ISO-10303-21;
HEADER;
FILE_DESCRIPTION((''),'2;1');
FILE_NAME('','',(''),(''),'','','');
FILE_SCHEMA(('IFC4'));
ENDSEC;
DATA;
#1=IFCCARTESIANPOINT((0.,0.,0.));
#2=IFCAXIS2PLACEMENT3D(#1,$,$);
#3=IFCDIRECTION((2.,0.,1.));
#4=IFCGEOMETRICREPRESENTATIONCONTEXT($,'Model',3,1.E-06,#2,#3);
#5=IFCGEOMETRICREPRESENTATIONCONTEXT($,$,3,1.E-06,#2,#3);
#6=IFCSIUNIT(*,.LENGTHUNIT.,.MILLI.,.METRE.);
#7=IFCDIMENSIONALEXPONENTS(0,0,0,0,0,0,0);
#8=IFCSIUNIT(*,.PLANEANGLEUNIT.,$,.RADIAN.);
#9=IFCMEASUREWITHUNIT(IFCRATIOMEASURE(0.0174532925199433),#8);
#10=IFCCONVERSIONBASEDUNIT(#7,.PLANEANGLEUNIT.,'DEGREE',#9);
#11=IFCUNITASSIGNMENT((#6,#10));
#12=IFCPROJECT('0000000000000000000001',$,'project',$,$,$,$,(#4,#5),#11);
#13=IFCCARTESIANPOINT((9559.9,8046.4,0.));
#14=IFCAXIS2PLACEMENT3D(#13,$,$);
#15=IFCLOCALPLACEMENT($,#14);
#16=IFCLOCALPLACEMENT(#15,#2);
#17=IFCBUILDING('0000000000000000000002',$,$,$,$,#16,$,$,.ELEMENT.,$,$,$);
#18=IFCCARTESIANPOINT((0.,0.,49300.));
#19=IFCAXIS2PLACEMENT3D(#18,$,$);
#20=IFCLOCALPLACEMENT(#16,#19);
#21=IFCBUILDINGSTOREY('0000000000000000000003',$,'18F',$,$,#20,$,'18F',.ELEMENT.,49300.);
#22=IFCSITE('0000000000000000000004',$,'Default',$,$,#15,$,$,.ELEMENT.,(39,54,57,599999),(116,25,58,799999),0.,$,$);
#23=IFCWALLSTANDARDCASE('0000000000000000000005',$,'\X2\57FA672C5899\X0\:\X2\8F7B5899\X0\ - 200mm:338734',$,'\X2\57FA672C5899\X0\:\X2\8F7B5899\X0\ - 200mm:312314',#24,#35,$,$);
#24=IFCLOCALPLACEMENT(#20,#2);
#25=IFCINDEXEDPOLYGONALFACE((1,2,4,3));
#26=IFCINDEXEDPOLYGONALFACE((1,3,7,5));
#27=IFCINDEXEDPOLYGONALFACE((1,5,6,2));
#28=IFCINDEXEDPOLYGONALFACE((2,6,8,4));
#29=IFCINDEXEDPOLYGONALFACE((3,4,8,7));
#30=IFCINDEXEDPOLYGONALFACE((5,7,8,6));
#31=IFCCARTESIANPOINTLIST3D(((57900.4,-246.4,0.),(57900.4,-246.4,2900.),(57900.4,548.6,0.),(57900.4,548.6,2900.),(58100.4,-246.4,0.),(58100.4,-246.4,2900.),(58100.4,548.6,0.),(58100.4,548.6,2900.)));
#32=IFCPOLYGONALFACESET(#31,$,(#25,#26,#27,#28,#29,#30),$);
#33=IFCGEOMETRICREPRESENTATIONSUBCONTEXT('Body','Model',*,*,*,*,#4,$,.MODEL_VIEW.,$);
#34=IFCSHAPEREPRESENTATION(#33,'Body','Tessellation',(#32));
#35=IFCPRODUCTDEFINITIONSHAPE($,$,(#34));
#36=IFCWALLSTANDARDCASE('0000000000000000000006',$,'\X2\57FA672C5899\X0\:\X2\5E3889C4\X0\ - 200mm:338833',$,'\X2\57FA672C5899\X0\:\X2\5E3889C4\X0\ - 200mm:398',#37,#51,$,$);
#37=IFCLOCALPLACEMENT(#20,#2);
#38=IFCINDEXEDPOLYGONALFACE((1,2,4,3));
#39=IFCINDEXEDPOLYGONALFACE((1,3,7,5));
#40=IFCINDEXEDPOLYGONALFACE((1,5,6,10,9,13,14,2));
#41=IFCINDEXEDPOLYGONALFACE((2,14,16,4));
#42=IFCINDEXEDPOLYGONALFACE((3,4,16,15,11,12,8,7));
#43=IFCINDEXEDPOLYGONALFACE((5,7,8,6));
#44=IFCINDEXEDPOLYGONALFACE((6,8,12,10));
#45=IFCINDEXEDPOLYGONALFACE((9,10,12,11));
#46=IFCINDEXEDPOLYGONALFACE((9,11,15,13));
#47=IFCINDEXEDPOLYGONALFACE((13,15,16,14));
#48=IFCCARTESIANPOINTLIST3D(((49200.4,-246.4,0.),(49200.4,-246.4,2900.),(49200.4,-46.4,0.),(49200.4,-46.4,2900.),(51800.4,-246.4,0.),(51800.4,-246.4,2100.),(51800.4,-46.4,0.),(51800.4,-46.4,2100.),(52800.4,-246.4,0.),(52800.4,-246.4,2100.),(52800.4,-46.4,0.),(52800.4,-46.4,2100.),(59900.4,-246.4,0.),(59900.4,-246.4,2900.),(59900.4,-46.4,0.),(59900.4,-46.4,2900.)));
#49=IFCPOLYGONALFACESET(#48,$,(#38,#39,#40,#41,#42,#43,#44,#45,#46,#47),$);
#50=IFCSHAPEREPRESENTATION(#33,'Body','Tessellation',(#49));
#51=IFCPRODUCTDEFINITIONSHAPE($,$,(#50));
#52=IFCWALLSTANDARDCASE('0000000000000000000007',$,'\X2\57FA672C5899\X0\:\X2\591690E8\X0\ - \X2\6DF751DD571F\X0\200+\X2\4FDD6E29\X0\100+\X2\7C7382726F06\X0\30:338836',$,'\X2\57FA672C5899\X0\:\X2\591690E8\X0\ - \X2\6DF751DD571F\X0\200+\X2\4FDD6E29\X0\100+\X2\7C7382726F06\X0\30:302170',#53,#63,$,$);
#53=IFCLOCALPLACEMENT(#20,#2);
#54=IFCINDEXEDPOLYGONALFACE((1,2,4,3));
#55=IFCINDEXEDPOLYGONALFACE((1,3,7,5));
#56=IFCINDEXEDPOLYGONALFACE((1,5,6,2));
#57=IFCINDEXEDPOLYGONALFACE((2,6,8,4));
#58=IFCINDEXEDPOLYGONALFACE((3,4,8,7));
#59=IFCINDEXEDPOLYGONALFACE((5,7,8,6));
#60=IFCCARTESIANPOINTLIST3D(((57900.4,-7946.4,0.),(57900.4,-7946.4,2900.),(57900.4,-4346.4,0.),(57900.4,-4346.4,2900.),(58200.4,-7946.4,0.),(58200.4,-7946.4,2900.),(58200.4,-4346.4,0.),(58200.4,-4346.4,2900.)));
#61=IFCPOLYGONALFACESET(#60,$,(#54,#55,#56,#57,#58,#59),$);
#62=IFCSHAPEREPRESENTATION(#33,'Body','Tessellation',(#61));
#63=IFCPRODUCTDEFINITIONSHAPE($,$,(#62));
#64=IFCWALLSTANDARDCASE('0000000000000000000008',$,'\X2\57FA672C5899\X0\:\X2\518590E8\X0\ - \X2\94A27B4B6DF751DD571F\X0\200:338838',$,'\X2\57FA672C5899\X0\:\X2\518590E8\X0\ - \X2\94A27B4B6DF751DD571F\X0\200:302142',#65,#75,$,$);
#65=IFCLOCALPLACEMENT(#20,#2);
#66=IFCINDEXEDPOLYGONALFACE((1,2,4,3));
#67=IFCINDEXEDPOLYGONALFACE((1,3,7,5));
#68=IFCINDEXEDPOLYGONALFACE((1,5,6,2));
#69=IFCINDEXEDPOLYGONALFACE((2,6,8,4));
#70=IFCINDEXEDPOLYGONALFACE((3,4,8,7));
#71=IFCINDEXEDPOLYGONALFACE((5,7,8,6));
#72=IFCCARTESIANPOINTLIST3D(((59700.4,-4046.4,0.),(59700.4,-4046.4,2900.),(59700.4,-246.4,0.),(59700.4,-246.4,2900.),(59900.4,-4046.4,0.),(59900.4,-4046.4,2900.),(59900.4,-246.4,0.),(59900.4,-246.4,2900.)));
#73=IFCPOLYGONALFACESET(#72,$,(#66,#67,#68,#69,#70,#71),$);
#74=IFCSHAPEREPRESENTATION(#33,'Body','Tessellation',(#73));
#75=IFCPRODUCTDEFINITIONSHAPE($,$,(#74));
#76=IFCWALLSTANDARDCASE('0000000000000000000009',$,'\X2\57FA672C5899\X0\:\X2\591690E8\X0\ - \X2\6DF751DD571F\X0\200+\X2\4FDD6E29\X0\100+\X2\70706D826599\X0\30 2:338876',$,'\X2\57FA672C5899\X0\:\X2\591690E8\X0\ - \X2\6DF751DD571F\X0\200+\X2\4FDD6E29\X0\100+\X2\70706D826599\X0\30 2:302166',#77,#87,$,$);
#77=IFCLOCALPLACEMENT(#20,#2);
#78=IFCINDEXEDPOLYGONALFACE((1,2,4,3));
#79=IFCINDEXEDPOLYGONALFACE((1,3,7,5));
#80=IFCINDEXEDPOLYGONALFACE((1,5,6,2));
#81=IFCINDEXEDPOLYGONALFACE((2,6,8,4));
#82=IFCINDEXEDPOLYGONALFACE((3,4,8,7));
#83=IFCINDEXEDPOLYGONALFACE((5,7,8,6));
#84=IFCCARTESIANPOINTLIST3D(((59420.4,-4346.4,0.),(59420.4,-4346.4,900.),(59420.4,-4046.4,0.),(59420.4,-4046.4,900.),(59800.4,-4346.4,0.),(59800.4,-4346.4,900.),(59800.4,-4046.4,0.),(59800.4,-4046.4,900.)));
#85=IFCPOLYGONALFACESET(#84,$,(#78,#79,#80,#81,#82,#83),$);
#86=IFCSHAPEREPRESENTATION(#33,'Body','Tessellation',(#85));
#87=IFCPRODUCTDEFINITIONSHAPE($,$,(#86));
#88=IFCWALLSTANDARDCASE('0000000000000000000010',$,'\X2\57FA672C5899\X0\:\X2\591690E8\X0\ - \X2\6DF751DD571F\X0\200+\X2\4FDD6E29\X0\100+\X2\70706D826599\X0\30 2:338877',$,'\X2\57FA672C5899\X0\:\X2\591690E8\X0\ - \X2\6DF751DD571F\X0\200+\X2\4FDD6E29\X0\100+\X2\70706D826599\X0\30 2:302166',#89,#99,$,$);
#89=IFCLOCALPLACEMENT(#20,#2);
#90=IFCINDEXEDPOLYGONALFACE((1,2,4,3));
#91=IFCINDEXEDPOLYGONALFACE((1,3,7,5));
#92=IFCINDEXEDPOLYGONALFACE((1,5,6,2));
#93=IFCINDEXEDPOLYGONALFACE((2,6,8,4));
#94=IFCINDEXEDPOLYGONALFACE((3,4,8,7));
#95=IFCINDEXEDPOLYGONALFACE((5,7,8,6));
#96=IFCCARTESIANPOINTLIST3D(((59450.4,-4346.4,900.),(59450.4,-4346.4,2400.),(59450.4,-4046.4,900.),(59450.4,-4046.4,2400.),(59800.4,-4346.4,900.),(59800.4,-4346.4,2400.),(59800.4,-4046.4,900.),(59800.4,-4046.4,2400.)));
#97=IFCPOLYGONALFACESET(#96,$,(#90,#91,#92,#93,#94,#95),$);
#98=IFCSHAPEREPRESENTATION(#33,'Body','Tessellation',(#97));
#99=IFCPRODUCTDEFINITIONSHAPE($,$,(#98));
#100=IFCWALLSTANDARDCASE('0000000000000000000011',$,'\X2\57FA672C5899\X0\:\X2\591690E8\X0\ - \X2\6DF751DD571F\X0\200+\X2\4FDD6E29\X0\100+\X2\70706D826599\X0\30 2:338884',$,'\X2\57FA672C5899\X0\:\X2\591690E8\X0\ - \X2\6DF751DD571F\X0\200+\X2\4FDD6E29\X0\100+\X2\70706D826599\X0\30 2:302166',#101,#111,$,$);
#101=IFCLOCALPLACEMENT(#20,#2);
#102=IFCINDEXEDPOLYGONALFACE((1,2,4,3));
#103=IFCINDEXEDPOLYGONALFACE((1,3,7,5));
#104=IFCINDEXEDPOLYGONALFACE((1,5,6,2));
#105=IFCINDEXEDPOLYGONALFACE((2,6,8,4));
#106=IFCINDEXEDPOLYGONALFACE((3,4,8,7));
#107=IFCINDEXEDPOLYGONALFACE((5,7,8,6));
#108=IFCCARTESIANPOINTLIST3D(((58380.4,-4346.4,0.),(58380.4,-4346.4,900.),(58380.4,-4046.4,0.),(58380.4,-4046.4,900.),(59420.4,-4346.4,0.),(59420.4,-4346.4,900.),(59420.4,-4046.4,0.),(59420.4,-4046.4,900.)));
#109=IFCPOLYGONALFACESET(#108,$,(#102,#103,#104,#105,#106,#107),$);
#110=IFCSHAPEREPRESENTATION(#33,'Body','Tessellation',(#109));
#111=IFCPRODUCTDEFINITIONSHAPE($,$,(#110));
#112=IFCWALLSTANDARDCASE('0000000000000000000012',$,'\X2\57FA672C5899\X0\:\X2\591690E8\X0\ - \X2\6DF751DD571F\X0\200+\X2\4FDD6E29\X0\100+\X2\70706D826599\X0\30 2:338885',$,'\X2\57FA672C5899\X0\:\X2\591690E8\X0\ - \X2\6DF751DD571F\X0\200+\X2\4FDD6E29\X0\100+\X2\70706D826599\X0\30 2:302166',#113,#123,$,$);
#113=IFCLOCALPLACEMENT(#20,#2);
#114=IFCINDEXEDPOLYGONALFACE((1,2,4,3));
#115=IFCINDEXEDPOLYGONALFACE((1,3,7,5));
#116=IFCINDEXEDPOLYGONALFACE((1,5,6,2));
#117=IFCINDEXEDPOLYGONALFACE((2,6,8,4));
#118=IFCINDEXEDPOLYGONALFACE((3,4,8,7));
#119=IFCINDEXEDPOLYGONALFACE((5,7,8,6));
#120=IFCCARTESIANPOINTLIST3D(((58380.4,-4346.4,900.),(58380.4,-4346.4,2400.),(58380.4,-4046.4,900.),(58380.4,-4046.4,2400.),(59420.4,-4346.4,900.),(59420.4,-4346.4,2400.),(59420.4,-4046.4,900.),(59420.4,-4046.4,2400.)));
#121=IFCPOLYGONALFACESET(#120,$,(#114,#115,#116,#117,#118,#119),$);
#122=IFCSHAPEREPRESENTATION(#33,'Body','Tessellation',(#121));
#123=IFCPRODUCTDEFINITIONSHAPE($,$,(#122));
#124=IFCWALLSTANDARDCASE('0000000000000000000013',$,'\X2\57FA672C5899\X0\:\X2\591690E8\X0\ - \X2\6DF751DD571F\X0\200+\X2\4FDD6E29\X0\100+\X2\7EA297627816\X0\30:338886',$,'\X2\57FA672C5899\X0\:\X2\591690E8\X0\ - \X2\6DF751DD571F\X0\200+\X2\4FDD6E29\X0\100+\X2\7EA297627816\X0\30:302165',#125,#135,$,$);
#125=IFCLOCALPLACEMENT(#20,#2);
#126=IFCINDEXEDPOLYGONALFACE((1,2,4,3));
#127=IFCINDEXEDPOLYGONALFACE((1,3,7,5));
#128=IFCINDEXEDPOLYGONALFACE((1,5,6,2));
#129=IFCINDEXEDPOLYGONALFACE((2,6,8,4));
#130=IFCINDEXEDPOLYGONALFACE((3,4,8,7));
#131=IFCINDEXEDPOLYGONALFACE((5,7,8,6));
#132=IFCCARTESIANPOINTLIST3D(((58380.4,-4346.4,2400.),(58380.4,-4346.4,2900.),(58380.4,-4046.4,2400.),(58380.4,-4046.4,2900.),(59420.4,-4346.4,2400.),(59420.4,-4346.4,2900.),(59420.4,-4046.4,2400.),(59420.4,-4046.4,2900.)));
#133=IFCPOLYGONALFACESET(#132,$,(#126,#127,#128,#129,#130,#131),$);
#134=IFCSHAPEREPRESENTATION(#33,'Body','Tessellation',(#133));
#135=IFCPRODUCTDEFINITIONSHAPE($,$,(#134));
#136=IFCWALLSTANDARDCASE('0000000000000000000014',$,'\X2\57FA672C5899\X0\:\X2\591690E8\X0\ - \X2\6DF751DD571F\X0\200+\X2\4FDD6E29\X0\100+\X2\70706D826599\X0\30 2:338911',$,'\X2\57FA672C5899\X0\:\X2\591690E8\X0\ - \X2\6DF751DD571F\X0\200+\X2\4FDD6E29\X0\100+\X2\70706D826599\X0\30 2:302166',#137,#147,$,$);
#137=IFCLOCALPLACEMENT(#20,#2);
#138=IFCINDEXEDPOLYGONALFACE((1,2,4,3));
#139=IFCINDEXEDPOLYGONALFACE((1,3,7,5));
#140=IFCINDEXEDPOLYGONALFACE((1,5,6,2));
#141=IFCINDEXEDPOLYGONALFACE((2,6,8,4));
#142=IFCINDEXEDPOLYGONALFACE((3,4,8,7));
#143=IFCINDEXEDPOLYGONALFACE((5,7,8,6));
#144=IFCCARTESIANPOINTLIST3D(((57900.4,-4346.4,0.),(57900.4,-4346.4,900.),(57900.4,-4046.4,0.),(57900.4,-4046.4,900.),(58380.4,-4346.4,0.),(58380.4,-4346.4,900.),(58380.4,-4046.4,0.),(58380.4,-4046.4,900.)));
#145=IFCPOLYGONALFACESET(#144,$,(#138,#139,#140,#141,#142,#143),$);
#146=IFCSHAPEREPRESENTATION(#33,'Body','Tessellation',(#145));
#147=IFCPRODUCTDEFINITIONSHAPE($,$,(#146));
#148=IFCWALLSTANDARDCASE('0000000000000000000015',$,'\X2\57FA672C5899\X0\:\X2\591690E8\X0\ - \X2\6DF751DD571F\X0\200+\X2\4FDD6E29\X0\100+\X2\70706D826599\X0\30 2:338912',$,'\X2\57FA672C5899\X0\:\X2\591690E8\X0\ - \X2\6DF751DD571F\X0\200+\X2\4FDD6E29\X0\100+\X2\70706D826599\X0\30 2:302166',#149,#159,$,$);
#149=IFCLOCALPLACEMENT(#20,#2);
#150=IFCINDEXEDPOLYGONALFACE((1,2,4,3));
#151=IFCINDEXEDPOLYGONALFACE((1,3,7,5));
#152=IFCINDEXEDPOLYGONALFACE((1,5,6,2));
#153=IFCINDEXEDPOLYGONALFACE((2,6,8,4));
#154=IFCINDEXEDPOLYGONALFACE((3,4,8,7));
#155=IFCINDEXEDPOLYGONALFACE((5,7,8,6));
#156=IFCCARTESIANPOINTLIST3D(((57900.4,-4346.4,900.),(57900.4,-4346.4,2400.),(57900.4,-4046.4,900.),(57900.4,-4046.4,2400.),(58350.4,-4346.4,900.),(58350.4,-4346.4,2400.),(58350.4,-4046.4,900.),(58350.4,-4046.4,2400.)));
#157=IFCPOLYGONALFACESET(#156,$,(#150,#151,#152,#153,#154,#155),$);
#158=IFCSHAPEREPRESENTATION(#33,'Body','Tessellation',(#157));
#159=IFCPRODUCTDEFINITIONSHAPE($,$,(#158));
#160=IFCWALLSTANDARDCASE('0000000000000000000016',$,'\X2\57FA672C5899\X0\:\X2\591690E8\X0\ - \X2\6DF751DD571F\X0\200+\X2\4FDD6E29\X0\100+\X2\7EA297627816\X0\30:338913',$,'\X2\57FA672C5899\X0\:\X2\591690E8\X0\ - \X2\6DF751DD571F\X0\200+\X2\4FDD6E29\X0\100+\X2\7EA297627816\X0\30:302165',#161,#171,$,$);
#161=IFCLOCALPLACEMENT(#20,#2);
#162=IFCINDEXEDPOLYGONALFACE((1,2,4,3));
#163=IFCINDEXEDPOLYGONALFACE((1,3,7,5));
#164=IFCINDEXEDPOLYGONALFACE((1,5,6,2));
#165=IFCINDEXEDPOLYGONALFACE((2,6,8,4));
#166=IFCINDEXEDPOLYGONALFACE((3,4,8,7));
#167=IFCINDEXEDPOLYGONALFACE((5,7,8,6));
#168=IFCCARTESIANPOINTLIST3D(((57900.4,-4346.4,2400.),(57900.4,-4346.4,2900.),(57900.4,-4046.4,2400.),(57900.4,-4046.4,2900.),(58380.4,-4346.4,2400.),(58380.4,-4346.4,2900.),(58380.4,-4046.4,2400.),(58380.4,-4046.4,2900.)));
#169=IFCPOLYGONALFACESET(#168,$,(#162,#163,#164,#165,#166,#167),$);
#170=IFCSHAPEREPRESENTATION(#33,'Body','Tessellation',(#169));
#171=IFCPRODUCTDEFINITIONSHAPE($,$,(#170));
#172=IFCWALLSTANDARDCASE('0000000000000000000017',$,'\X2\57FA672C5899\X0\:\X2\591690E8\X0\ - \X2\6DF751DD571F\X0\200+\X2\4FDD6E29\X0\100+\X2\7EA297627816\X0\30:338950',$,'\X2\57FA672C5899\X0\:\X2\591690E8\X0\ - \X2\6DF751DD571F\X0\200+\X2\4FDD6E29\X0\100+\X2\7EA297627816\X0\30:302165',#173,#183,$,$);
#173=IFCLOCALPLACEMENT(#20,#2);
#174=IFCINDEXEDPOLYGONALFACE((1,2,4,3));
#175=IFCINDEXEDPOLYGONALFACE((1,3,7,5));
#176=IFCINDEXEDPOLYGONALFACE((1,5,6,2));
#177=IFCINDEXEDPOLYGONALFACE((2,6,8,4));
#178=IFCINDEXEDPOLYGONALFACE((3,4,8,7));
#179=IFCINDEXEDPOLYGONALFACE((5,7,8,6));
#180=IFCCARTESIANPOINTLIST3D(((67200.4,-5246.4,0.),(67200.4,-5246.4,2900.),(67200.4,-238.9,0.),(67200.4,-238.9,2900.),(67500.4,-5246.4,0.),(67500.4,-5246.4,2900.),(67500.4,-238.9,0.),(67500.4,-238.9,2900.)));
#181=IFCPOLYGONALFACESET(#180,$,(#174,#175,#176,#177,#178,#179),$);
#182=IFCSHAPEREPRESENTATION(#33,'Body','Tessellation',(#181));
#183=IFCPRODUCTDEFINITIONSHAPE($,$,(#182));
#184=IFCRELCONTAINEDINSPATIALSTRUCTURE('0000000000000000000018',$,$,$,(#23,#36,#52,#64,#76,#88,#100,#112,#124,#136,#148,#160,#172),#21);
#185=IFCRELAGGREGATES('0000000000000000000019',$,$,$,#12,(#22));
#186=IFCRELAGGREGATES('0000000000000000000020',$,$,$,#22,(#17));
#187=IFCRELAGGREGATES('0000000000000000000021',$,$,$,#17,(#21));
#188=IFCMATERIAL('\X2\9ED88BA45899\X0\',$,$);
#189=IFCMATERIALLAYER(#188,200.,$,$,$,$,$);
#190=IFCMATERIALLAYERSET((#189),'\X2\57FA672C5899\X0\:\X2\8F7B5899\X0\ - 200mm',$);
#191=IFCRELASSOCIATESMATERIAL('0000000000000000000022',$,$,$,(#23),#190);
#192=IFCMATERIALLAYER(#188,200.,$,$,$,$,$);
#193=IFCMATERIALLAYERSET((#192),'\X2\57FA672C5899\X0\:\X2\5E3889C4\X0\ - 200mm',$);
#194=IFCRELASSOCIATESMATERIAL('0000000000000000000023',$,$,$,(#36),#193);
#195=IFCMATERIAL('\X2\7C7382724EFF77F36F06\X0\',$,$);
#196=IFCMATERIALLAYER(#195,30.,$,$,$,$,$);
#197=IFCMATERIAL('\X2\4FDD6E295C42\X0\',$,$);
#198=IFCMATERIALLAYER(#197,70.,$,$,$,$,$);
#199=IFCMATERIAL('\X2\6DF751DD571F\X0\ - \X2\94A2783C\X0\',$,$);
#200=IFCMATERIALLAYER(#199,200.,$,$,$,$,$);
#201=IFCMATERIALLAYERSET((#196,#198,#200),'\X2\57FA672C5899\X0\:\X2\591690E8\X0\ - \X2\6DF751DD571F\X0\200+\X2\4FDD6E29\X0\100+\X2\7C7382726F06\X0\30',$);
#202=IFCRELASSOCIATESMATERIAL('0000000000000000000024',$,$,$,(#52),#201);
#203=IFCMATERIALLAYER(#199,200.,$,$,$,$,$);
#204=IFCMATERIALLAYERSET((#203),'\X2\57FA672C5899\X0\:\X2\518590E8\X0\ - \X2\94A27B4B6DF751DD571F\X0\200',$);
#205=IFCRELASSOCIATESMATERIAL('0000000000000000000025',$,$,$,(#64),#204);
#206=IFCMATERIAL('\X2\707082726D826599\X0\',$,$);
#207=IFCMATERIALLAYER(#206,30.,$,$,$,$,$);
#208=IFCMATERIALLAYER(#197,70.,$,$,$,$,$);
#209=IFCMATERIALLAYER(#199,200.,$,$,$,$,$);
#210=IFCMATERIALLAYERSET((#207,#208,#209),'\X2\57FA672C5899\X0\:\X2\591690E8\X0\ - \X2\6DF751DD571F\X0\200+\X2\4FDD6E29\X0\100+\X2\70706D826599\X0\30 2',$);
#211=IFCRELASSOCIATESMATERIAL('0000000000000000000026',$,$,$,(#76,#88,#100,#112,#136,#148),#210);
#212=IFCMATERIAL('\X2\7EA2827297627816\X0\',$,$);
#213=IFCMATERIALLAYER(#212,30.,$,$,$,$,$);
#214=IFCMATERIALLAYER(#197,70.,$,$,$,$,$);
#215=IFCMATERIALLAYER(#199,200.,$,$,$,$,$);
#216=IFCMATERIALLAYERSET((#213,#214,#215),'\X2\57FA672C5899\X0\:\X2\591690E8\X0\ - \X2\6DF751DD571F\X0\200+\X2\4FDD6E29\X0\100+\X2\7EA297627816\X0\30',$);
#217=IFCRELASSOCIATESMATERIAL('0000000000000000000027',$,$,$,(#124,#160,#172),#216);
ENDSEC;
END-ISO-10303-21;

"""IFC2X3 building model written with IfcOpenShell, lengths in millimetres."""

from ifc_helpers import new_model, entity, si_unit, converted_unit, direction, frame, frame_2d, origin, place, context, subcontext, project, spatial, rectangle, extrude, material, layer, layer_set, layer_usage, element, save


model = new_model("IFC2X3")

# Units and contexts
model_context = context("Model", 3, precision=1e-06, world=origin(), true_north=direction((2.0, 0.0, 1.0)))
context_of_model = context(None, 3, precision=1e-06, world=origin(), true_north=direction((2.0, 0.0, 1.0)))
body_context = subcontext(model_context, "Body", "Model", "MODEL_VIEW")
ifc_project = project(units=[si_unit("LENGTHUNIT", "METRE", prefix="MILLI"), converted_unit("PLANEANGLEUNIT", "DEGREE", entity("IfcRatioMeasure", 0.0174532925199433), si_unit("PLANEANGLEUNIT", "RADIAN"), dimensions=[0, 0, 0, 0, 0, 0, 0])], contexts=[model_context, context_of_model])

# Site, building, storey
site_placement = place(None, frame((9559.9, 8046.4, 0.0)))
site = spatial("IfcSite", under=ifc_project, at=site_placement, Name="Default", CompositionType="ELEMENT", RefLatitude=(39, 54, 57, 599999), RefLongitude=(116, 25, 58, 799999), RefElevation=0.0)
building_placement = place(site_placement, origin())
building = spatial("IfcBuilding", under=site, at=building_placement, CompositionType="ELEMENT")
storey_placement = place(building_placement, frame((0.0, 0.0, 49300.0)))
storey = spatial("IfcBuildingStorey", under=building, at=storey_placement, Name="18F", LongName="18F", CompositionType="ELEMENT", Elevation=49300.0)

# Wall
ifc_material_1 = material(Name="默认墙")
ifc_layer_1 = layer(ifc_material_1, 200.0)
ifc_layer_set_1 = layer_set([ifc_layer_1], Name="基本墙:轻墙 - 200mm")
ifc_layer_usage_1 = layer_usage(ifc_layer_set_1, "AXIS2", "POSITIVE", -100.0)
wall_1_placement = place(storey_placement, frame((58000.4, -246.4, 0.0), z_axis=(0.0, 0.0, 1.0), x_axis=(0.0, 1.0, 0.0)))
element("IfcWallStandardCase", 1, at=wall_1_placement, inside=storey, material=ifc_layer_usage_1, Name="基本墙:轻墙 - 200mm:338734", ObjectType="基本墙:轻墙 - 200mm:312314", context=body_context, shape_type="SweptSolid", body=[
    extrude(rectangle(XDim=795.0, YDim=200.0, at=frame_2d((397.5, 0.0), x_axis=(-1.0, 0.0))), origin(), (0.0, 0.0, 1.0), 2900.0),
])

# Wall, opening
ifc_layer_2 = layer(ifc_material_1, 200.0)
ifc_layer_set_2 = layer_set([ifc_layer_2], Name="基本墙:常规 - 200mm")
ifc_layer_usage_2 = layer_usage(ifc_layer_set_2, "AXIS2", "POSITIVE", -100.0)
wall_2_placement = place(storey_placement, frame((59900.4, -146.4, 0.0), z_axis=(0.0, 0.0, 1.0), x_axis=(-1.0, 0.0, 0.0)))
wall_2 = element("IfcWallStandardCase", 2, at=wall_2_placement, inside=storey, material=ifc_layer_usage_2, Name="基本墙:常规 - 200mm:338833", ObjectType="基本墙:常规 - 200mm:398", context=body_context, shape_type="SweptSolid", body=[
    extrude(rectangle(XDim=10700.0, YDim=200.0, at=frame_2d((5350.0, 0.0), x_axis=(-1.0, 0.0))), origin(), (0.0, 0.0, 1.0), 2900.0),
])
opening_1_placement = place(wall_2_placement, frame((8100.0, 100.0, 0.0)))
element("IfcOpeningElement", 3, at=opening_1_placement, cuts=wall_2, ObjectType="Opening", context=body_context, shape_type="SweptSolid", body=[
    extrude(rectangle(XDim=2100.0, YDim=1000.0, at=frame_2d((1050.0, 500.0), x_axis=(1.0, 0.0))), frame((0.0, 0.0, 0.0), z_axis=(0.0, -1.0, 0.0), x_axis=(0.0, 0.0, 1.0)), (0.0, 0.0, 1.0), 200.0),
])

# Walls
ifc_material_2 = material(Name="米色仿石漆")
ifc_layer_3 = layer(ifc_material_2, 30.0)
ifc_material_3 = material(Name="保温层")
ifc_layer_4 = layer(ifc_material_3, 70.0)
ifc_material_4 = material(Name="混凝土 - 钢砼")
ifc_layer_5 = layer(ifc_material_4, 200.0)
ifc_layer_set_3 = layer_set([ifc_layer_3, ifc_layer_4, ifc_layer_5], Name="基本墙:外部 - 混凝土200+保温100+米色漆30")
ifc_layer_usage_3 = layer_usage(ifc_layer_set_3, "AXIS2", "POSITIVE", -150.0)
wall_3_placement = place(storey_placement, frame((58050.4, -7946.4, 0.0), z_axis=(0.0, 0.0, 1.0), x_axis=(0.0, 1.0, 0.0)))
element("IfcWallStandardCase", 4, at=wall_3_placement, inside=storey, material=ifc_layer_usage_3, Name="基本墙:外部 - 混凝土200+保温100+米色漆30:338836", ObjectType="基本墙:外部 - 混凝土200+保温100+米色漆30:302170", context=body_context, shape_type="SweptSolid", body=[
    extrude(rectangle(XDim=3600.0, YDim=300.0, at=frame_2d((1800.0, 0.0), x_axis=(-1.0, 0.0))), origin(), (0.0, 0.0, 1.0), 2900.0),
])
ifc_layer_6 = layer(ifc_material_4, 200.0)
ifc_layer_set_4 = layer_set([ifc_layer_6], Name="基本墙:内部 - 钢筋混凝土200")
ifc_layer_usage_4 = layer_usage(ifc_layer_set_4, "AXIS2", "POSITIVE", -100.0)
wall_4_placement = place(storey_placement, frame((59800.4, -4046.4, 0.0), z_axis=(0.0, 0.0, 1.0), x_axis=(0.0, 1.0, 0.0)))
element("IfcWallStandardCase", 5, at=wall_4_placement, inside=storey, material=ifc_layer_usage_4, Name="基本墙:内部 - 钢筋混凝土200:338838", ObjectType="基本墙:内部 - 钢筋混凝土200:302142", context=body_context, shape_type="SweptSolid", body=[
    extrude(rectangle(XDim=3800.0, YDim=200.0, at=frame_2d((1900.0, 0.0), x_axis=(-1.0, 0.0))), origin(), (0.0, 0.0, 1.0), 2900.0),
])
ifc_material_5 = material(Name="灰色涂料")
ifc_layer_7 = layer(ifc_material_5, 30.0)
ifc_layer_8 = layer(ifc_material_3, 70.0)
ifc_layer_9 = layer(ifc_material_4, 200.0)
ifc_layer_set_5 = layer_set([ifc_layer_7, ifc_layer_8, ifc_layer_9], Name="基本墙:外部 - 混凝土200+保温100+灰涂料30 2")
ifc_layer_usage_5 = layer_usage(ifc_layer_set_5, "AXIS2", "POSITIVE", -150.0)
wall_5_placement = place(storey_placement, frame((59420.4, -4196.4, 0.0)))
element("IfcWallStandardCase", 6, at=wall_5_placement, inside=storey, material=ifc_layer_usage_5, Name="基本墙:外部 - 混凝土200+保温100+灰涂料30 2:338876", ObjectType="基本墙:外部 - 混凝土200+保温100+灰涂料30 2:302166", context=body_context, shape_type="SweptSolid", body=[
    extrude(rectangle(XDim=380.0, YDim=300.0, at=frame_2d((190.0, 0.0), x_axis=(-1.0, 0.0))), origin(), (0.0, 0.0, 1.0), 900.0),
])
ifc_layer_usage_6 = layer_usage(ifc_layer_set_5, "AXIS2", "POSITIVE", -150.0)
wall_6_placement = place(storey_placement, frame((59450.4, -4196.4, 900.0)))
element("IfcWallStandardCase", 7, at=wall_6_placement, inside=storey, material=ifc_layer_usage_6, Name="基本墙:外部 - 混凝土200+保温100+灰涂料30 2:338877", ObjectType="基本墙:外部 - 混凝土200+保温100+灰涂料30 2:302166", context=body_context, shape_type="SweptSolid", body=[
    extrude(rectangle(XDim=350.0, YDim=300.0, at=frame_2d((175.0, 0.0), x_axis=(-1.0, 0.0))), origin(), (0.0, 0.0, 1.0), 1500.0),
])

# Shared definitions
ifc_material_6 = material(Name="红色面砖")
ifc_layer_10 = layer(ifc_material_6, 30.0)
ifc_layer_11 = layer(ifc_material_3, 70.0)
ifc_layer_12 = layer(ifc_material_4, 200.0)
ifc_layer_set_6 = layer_set([ifc_layer_10, ifc_layer_11, ifc_layer_12], Name="基本墙:外部 - 混凝土200+保温100+红面砖30")

# Walls
ifc_layer_usage_7 = layer_usage(ifc_layer_set_5, "AXIS2", "POSITIVE", -150.0)
wall_7_placement = place(storey_placement, frame((58380.4, -4196.4, 0.0)))
element("IfcWallStandardCase", 8, at=wall_7_placement, inside=storey, material=ifc_layer_usage_7, Name="基本墙:外部 - 混凝土200+保温100+灰涂料30 2:338884", ObjectType="基本墙:外部 - 混凝土200+保温100+灰涂料30 2:302166", context=body_context, shape_type="SweptSolid", body=[
    extrude(rectangle(XDim=1040.0, YDim=300.0, at=frame_2d((520.0, 0.0), x_axis=(-1.0, 0.0))), origin(), (0.0, 0.0, 1.0), 900.0),
])
ifc_layer_usage_8 = layer_usage(ifc_layer_set_5, "AXIS2", "POSITIVE", -150.0)
wall_8_placement = place(storey_placement, frame((58380.4, -4196.4, 900.0)))
element("IfcWallStandardCase", 9, at=wall_8_placement, inside=storey, material=ifc_layer_usage_8, Name="基本墙:外部 - 混凝土200+保温100+灰涂料30 2:338885", ObjectType="基本墙:外部 - 混凝土200+保温100+灰涂料30 2:302166", context=body_context, shape_type="SweptSolid", body=[
    extrude(rectangle(XDim=1040.0, YDim=300.0, at=frame_2d((520.0, 0.0), x_axis=(-1.0, 0.0))), origin(), (0.0, 0.0, 1.0), 1500.0),
])
ifc_layer_usage_9 = layer_usage(ifc_layer_set_6, "AXIS2", "POSITIVE", -150.0)
wall_9_placement = place(storey_placement, frame((58380.4, -4196.4, 2400.0)))
element("IfcWallStandardCase", 10, at=wall_9_placement, inside=storey, material=ifc_layer_usage_9, Name="基本墙:外部 - 混凝土200+保温100+红面砖30:338886", ObjectType="基本墙:外部 - 混凝土200+保温100+红面砖30:302165", context=body_context, shape_type="SweptSolid", body=[
    extrude(rectangle(XDim=1040.0, YDim=300.0, at=frame_2d((520.0, 0.0), x_axis=(-1.0, 0.0))), origin(), (0.0, 0.0, 1.0), 500.0),
])
ifc_layer_usage_10 = layer_usage(ifc_layer_set_5, "AXIS2", "POSITIVE", -150.0)
wall_10_placement = place(storey_placement, frame((57900.4, -4196.4, 0.0)))
element("IfcWallStandardCase", 11, at=wall_10_placement, inside=storey, material=ifc_layer_usage_10, Name="基本墙:外部 - 混凝土200+保温100+灰涂料30 2:338911", ObjectType="基本墙:外部 - 混凝土200+保温100+灰涂料30 2:302166", context=body_context, shape_type="SweptSolid", body=[
    extrude(rectangle(XDim=480.0, YDim=300.0, at=frame_2d((240.0, 0.0), x_axis=(-1.0, 0.0))), origin(), (0.0, 0.0, 1.0), 900.0),
])
ifc_layer_usage_11 = layer_usage(ifc_layer_set_5, "AXIS2", "POSITIVE", -150.0)
wall_11_placement = place(storey_placement, frame((57900.4, -4196.4, 900.0)))
element("IfcWallStandardCase", 12, at=wall_11_placement, inside=storey, material=ifc_layer_usage_11, Name="基本墙:外部 - 混凝土200+保温100+灰涂料30 2:338912", ObjectType="基本墙:外部 - 混凝土200+保温100+灰涂料30 2:302166", context=body_context, shape_type="SweptSolid", body=[
    extrude(rectangle(XDim=450.0, YDim=300.0, at=frame_2d((225.0, 0.0), x_axis=(-1.0, 0.0))), origin(), (0.0, 0.0, 1.0), 1500.0),
])
ifc_layer_usage_12 = layer_usage(ifc_layer_set_6, "AXIS2", "POSITIVE", -150.0)
wall_12_placement = place(storey_placement, frame((57900.4, -4196.4, 2400.0)))
element("IfcWallStandardCase", 13, at=wall_12_placement, inside=storey, material=ifc_layer_usage_12, Name="基本墙:外部 - 混凝土200+保温100+红面砖30:338913", ObjectType="基本墙:外部 - 混凝土200+保温100+红面砖30:302165", context=body_context, shape_type="SweptSolid", body=[
    extrude(rectangle(XDim=480.0, YDim=300.0, at=frame_2d((240.0, 0.0), x_axis=(-1.0, 0.0))), origin(), (0.0, 0.0, 1.0), 500.0),
])
ifc_layer_usage_13 = layer_usage(ifc_layer_set_6, "AXIS2", "POSITIVE", -150.0)
wall_13_placement = place(storey_placement, frame((67350.4, -5246.4, 0.0), z_axis=(0.0, 0.0, 1.0), x_axis=(0.0, 1.0, 0.0)))
element("IfcWallStandardCase", 14, at=wall_13_placement, inside=storey, material=ifc_layer_usage_13, Name="基本墙:外部 - 混凝土200+保温100+红面砖30:338950", ObjectType="基本墙:外部 - 混凝土200+保温100+红面砖30:302165", context=body_context, shape_type="SweptSolid", body=[
    extrude(rectangle(XDim=5007.5, YDim=300.0, at=frame_2d((2503.8, 0.0), x_axis=(-1.0, 0.0))), origin(), (0.0, 0.0, 1.0), 2900.0),
])

save(model, "model.ifc")
